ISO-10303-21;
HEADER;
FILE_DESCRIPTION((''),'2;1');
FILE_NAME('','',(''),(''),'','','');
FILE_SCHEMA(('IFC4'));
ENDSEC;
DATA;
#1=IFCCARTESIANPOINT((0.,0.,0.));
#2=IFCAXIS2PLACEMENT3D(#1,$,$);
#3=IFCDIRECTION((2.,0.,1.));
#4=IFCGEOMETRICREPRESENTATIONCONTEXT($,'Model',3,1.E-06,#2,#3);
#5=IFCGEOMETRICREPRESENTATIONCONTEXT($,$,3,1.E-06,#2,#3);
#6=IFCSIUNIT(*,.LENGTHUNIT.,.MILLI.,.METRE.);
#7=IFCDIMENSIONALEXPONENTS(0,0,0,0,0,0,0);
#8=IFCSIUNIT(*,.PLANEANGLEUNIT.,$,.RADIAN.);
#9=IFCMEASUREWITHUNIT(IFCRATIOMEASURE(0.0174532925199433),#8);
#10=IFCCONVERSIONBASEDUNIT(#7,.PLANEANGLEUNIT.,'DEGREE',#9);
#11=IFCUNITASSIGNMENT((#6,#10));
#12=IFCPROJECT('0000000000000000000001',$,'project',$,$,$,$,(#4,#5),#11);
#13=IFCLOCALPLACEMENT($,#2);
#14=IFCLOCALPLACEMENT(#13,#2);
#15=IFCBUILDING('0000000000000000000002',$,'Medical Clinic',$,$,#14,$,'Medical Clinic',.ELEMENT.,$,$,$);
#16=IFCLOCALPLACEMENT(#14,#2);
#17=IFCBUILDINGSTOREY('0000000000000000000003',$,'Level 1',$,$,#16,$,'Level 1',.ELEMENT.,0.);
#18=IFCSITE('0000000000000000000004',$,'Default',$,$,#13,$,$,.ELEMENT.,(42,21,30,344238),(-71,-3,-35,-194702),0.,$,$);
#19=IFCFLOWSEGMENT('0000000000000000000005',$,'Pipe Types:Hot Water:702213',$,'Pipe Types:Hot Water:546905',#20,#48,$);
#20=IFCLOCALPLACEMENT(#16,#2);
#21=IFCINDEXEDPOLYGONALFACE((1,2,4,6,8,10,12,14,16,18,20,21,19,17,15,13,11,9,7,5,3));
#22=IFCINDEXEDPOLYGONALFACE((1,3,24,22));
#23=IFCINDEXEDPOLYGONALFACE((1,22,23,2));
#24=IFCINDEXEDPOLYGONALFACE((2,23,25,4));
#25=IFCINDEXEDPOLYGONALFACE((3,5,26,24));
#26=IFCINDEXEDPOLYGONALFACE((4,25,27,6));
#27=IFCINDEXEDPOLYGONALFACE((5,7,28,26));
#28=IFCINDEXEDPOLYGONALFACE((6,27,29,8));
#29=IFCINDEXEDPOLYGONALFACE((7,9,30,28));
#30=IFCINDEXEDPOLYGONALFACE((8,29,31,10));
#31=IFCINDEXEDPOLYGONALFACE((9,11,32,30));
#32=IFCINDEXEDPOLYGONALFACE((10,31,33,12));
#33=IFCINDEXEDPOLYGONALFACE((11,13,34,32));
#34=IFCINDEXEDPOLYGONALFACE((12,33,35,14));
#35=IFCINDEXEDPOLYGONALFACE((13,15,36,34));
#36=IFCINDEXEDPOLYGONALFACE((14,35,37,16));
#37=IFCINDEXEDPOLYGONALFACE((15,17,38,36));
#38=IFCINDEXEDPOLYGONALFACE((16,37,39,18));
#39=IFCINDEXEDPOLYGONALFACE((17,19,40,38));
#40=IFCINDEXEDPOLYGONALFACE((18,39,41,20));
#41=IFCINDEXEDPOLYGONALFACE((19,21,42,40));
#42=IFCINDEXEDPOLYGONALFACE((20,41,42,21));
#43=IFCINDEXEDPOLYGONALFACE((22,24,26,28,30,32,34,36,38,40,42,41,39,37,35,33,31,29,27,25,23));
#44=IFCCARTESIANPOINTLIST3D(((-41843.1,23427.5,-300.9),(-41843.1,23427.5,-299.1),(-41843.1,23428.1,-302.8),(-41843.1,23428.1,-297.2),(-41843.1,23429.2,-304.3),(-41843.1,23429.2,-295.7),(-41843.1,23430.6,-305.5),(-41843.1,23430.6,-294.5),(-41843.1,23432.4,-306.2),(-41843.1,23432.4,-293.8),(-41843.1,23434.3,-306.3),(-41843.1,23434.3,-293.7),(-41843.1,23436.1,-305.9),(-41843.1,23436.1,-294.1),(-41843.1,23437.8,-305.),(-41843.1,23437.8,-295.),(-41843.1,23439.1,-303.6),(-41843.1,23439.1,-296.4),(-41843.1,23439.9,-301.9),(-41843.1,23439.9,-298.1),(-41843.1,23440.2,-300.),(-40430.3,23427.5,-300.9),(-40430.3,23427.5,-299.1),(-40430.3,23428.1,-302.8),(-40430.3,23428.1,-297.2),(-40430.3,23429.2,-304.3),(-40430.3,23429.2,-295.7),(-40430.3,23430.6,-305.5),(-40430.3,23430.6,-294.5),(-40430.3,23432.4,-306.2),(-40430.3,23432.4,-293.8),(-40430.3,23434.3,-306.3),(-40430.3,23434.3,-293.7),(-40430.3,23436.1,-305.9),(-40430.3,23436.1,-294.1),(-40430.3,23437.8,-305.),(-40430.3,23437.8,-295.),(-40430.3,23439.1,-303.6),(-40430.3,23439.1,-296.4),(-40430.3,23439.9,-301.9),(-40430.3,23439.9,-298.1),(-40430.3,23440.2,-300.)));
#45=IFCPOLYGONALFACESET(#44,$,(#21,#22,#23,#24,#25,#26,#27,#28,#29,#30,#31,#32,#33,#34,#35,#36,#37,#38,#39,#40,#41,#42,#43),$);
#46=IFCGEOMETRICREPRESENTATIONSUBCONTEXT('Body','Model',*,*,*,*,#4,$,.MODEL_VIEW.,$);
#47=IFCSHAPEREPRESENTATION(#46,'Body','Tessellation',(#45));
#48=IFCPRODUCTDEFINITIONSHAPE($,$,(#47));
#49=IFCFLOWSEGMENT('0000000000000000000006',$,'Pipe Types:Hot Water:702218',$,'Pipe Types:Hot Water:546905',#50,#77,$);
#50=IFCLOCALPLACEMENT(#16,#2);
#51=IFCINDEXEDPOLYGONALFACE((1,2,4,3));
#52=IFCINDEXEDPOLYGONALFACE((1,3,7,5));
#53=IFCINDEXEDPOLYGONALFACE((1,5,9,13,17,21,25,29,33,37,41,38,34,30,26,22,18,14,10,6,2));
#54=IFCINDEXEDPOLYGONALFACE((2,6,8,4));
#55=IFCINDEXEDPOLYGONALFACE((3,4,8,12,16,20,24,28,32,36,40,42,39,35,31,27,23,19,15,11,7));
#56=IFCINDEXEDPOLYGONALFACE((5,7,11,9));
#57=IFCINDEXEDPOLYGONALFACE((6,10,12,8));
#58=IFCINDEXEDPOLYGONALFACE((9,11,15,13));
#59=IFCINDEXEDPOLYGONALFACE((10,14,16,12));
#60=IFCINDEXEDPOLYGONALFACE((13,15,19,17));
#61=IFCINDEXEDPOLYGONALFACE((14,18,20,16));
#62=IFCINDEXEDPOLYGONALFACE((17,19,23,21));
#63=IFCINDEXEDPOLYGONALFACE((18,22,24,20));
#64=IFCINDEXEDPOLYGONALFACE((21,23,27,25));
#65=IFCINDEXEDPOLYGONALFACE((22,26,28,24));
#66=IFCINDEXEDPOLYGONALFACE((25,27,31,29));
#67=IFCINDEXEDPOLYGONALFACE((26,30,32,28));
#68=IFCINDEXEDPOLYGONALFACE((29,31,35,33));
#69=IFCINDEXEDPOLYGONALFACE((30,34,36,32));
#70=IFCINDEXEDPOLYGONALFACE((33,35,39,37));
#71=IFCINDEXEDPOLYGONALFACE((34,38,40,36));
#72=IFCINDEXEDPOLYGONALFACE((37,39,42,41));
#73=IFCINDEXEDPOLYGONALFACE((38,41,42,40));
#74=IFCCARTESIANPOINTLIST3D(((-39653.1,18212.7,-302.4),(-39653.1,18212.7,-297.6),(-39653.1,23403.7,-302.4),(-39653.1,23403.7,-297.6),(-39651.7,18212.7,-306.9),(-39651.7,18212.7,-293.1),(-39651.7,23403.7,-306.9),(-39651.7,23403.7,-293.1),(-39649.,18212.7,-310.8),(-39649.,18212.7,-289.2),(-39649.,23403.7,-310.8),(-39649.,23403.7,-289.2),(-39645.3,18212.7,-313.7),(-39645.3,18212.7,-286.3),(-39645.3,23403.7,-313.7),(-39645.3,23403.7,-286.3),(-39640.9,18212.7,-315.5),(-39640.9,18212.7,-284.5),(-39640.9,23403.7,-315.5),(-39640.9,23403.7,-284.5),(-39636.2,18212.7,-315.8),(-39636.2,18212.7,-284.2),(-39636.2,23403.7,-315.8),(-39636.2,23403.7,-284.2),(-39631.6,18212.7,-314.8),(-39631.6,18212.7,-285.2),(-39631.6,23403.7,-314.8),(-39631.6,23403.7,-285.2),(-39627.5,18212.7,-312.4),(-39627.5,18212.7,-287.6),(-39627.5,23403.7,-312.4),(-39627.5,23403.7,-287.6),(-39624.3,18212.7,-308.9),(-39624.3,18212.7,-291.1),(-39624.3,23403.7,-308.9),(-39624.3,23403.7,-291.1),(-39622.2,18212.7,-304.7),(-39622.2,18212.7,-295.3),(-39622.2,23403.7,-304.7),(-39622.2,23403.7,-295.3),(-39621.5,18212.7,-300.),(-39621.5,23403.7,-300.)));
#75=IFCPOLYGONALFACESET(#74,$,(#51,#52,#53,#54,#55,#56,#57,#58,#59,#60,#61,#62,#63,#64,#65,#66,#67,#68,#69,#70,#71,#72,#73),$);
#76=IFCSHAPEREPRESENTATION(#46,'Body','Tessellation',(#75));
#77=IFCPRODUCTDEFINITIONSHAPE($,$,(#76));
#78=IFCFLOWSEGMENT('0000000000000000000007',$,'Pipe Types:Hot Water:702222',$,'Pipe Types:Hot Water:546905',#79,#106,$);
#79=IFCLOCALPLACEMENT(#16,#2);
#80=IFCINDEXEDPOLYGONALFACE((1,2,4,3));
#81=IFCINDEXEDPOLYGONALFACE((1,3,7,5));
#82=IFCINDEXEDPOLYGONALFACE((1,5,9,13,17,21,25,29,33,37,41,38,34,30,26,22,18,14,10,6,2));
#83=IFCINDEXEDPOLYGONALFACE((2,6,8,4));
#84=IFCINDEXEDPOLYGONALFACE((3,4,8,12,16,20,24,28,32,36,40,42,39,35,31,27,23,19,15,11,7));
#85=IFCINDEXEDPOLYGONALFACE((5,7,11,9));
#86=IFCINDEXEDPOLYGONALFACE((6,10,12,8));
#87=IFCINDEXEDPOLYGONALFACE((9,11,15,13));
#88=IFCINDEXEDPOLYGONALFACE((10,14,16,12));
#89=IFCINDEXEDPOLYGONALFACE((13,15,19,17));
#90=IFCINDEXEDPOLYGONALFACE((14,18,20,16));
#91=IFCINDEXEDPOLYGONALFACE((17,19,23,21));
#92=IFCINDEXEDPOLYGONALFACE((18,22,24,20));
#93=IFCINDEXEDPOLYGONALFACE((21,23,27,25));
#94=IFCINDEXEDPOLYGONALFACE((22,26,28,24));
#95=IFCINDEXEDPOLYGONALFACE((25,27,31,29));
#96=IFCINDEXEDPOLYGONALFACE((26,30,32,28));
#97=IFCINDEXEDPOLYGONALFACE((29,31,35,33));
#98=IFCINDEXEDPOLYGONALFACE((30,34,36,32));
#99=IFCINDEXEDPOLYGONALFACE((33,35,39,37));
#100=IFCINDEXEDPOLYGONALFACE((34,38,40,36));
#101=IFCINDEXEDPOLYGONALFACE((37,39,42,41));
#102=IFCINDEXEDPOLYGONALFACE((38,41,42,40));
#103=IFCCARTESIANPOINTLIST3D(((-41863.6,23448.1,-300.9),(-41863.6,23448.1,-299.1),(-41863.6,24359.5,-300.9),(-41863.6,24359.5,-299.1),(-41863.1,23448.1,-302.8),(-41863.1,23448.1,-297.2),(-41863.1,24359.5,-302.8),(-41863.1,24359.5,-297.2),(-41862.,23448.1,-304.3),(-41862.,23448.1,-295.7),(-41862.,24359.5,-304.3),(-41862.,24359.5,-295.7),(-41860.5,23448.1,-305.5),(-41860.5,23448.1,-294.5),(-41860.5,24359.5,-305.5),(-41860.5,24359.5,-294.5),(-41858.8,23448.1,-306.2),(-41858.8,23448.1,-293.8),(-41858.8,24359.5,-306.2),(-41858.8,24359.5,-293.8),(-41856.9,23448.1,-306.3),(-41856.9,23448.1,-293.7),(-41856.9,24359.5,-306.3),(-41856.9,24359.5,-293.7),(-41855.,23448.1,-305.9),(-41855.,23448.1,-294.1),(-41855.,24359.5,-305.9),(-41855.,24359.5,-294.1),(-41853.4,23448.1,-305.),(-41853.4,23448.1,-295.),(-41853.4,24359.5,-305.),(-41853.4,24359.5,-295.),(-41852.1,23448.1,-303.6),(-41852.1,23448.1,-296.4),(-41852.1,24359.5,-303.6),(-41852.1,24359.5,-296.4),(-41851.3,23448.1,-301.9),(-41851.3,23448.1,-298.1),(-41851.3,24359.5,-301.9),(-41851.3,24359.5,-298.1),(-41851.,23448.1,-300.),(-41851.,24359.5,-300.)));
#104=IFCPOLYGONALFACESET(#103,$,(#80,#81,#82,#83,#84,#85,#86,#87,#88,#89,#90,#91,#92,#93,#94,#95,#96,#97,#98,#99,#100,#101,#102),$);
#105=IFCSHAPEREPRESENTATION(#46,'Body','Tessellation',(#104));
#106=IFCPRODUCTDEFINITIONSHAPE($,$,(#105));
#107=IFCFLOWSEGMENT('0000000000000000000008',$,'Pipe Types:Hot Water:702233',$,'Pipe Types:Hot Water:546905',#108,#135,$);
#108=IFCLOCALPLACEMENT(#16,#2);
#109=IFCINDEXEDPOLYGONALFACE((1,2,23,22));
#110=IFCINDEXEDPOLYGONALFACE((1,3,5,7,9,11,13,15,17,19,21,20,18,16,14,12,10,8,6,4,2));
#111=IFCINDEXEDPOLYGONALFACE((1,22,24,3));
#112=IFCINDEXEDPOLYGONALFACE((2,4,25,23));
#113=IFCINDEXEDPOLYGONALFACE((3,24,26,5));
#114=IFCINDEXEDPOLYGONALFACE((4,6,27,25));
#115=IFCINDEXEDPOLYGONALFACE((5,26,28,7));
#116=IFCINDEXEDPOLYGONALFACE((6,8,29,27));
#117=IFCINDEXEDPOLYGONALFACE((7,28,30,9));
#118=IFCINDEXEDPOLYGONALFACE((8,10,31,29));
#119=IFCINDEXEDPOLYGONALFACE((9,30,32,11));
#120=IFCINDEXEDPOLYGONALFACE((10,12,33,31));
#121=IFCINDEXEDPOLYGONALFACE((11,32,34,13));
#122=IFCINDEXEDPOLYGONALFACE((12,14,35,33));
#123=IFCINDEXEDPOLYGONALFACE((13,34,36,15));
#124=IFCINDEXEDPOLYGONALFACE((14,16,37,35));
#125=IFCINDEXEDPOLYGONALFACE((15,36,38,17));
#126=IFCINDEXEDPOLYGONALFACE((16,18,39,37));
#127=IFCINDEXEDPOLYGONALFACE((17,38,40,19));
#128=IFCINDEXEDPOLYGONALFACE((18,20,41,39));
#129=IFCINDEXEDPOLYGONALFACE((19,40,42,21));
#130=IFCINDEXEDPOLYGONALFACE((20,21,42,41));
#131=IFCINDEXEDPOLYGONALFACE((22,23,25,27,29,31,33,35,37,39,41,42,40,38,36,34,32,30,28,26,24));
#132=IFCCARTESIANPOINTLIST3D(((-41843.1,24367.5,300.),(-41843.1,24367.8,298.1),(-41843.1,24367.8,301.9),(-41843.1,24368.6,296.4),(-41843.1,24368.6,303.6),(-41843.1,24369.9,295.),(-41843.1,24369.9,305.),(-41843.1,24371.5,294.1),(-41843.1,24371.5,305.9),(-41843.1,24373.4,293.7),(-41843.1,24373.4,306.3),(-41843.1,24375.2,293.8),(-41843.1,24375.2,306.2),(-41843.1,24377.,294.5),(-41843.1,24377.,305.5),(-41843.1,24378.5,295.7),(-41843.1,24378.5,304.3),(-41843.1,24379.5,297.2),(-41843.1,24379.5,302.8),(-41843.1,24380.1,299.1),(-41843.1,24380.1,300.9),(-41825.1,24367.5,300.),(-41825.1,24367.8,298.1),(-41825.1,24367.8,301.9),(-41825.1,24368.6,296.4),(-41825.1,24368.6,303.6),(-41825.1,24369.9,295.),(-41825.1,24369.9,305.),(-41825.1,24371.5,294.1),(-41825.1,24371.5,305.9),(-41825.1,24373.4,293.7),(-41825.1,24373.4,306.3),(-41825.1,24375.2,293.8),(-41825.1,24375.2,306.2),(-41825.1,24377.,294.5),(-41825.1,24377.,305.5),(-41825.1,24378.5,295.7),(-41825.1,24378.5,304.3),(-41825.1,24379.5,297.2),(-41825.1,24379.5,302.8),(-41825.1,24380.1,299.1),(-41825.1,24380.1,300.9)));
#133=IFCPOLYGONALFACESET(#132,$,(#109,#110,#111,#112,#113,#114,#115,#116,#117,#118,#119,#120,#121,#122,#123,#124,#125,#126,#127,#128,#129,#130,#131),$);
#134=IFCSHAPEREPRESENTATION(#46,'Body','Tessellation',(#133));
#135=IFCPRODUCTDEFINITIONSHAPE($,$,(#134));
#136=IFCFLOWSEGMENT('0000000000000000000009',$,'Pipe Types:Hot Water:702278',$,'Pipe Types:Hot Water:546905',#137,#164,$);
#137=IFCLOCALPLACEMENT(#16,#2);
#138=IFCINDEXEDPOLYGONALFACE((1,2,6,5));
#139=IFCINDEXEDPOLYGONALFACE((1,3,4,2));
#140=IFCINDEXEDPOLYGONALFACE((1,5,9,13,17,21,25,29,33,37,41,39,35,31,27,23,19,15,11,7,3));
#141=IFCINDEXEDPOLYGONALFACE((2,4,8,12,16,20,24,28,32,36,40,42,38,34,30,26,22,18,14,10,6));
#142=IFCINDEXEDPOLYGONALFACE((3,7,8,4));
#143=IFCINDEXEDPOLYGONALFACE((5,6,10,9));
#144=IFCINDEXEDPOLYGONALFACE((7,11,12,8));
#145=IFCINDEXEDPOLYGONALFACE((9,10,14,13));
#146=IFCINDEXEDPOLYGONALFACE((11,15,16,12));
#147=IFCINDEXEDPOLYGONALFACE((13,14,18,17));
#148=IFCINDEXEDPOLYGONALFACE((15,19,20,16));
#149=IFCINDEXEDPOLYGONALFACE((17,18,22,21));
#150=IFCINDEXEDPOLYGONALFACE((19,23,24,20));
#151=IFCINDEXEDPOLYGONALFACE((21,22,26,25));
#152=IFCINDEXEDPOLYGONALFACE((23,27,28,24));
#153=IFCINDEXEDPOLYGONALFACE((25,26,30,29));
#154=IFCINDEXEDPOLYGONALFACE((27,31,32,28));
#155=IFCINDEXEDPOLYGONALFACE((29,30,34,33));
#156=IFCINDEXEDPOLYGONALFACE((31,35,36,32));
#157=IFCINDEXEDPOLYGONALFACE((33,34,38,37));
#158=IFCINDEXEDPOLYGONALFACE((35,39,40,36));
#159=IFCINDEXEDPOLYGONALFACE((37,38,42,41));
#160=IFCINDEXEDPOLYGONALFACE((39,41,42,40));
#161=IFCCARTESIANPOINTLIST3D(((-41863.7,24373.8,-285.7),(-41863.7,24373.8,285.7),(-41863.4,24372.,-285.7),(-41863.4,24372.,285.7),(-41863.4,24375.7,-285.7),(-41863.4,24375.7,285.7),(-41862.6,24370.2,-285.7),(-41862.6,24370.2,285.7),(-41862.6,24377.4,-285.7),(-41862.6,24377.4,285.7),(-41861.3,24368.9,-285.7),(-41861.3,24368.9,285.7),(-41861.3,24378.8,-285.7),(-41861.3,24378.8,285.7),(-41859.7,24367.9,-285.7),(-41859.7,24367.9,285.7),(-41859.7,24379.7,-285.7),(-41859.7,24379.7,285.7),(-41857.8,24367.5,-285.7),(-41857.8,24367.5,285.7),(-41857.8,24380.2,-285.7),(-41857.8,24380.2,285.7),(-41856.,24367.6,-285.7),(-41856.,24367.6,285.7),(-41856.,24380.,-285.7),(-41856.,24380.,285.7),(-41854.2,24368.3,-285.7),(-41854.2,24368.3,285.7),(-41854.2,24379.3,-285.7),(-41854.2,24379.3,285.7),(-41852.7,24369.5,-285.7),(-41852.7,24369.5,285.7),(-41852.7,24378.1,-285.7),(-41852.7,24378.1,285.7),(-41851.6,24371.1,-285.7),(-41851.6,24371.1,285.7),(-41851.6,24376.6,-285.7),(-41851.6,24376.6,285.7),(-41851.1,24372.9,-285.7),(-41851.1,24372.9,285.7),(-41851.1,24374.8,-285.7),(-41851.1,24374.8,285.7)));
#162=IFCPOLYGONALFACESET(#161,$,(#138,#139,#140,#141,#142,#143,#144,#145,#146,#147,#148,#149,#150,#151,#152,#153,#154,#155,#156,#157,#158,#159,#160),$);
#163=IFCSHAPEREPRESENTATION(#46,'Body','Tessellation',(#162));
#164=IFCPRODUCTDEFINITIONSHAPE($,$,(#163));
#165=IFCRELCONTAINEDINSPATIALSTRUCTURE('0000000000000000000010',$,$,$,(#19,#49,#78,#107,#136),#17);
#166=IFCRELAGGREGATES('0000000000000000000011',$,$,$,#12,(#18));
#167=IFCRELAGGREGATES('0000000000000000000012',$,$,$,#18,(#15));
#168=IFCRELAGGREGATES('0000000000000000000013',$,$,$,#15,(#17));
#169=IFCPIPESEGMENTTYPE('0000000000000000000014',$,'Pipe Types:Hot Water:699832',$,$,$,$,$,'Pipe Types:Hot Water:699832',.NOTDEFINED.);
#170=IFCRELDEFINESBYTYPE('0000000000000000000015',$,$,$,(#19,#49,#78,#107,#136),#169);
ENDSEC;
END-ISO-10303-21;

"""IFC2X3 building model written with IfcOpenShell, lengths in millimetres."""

from ifc_helpers import new_model, entity, si_unit, converted_unit, direction, frame, frame_2d, origin, origin_2d_with_axis, place, context, subcontext, project, spatial, circle, extrude, type_object, element, save


model = new_model("IFC2X3")

# Units and contexts
model_context = context("Model", 3, precision=1e-06, world=origin(), true_north=direction((2.0, 0.0, 1.0)))
context_of_model = context(None, 3, precision=1e-06, world=origin(), true_north=direction((2.0, 0.0, 1.0)))
body_context = subcontext(model_context, "Body", "Model", "MODEL_VIEW")
ifc_project = project(units=[si_unit("LENGTHUNIT", "METRE", prefix="MILLI"), converted_unit("PLANEANGLEUNIT", "DEGREE", entity("IfcRatioMeasure", 0.0174532925199433), si_unit("PLANEANGLEUNIT", "RADIAN"), dimensions=[0, 0, 0, 0, 0, 0, 0])], contexts=[model_context, context_of_model])

# Site, building, storey
site_placement = place(None, origin())
site = spatial("IfcSite", under=ifc_project, at=site_placement, Name="Default", CompositionType="ELEMENT", RefLatitude=(42, 21, 30, 344238), RefLongitude=(-71, -3, -35, -194702), RefElevation=0.0)
building_placement = place(site_placement, origin())
building = spatial("IfcBuilding", under=site, at=building_placement, Name="Medical Clinic", LongName="Medical Clinic", CompositionType="ELEMENT")
storey_placement = place(building_placement, origin())
storey = spatial("IfcBuildingStorey", under=building, at=storey_placement, Name="Level 1", LongName="Level 1", CompositionType="ELEMENT", Elevation=0.0)

# Flow segments
pipe_segment_type_1 = type_object("IfcPipeSegmentType", Name="Pipe Types:Hot Water:699832", ElementType="Pipe Types:Hot Water:699832", PredefinedType="NOTDEFINED")
flow_segment_1_placement = place(storey_placement, origin())
element("IfcFlowSegment", 1, at=flow_segment_1_placement, inside=storey, type_object=pipe_segment_type_1, Name="Pipe Types:Hot Water:702213", ObjectType="Pipe Types:Hot Water:546905", context=body_context, shape_type="SweptSolid", body=[
    extrude(circle(Radius=6.3, at=frame_2d((0.0, 0.0), x_axis=(1.0, 0.0))), frame((-41843.1, 23433.8, -300.0), z_axis=(1.0, 0.0, 0.0), x_axis=(0.0, 1.0, 0.0)), (0.0, 0.0, 1.0), 1412.7),
])
flow_segment_2_placement = place(storey_placement, origin())
element("IfcFlowSegment", 2, at=flow_segment_2_placement, inside=storey, type_object=pipe_segment_type_1, Name="Pipe Types:Hot Water:702218", ObjectType="Pipe Types:Hot Water:546905", context=body_context, shape_type="SweptSolid", body=[
    extrude(circle(Radius=15.9, at=origin_2d_with_axis()), frame((-39637.4, 18212.7, -300.0), z_axis=(0.0, 1.0, 0.0), x_axis=(1.0, 0.0, 0.0)), (0.0, 0.0, 1.0), 5191.0),
])
flow_segment_3_placement = place(storey_placement, origin())
element("IfcFlowSegment", 3, at=flow_segment_3_placement, inside=storey, type_object=pipe_segment_type_1, Name="Pipe Types:Hot Water:702222", ObjectType="Pipe Types:Hot Water:546905", context=body_context, shape_type="SweptSolid", body=[
    extrude(circle(Radius=6.3, at=origin_2d_with_axis()), frame((-41857.4, 23448.1, -300.0), z_axis=(0.0, 1.0, 0.0), x_axis=(1.0, 0.0, 0.0)), (0.0, 0.0, 1.0), 911.4),
])
flow_segment_4_placement = place(storey_placement, origin())
element("IfcFlowSegment", 4, at=flow_segment_4_placement, inside=storey, type_object=pipe_segment_type_1, Name="Pipe Types:Hot Water:702233", ObjectType="Pipe Types:Hot Water:546905", context=body_context, shape_type="SweptSolid", body=[
    extrude(circle(Radius=6.3, at=origin_2d_with_axis()), frame((-41843.1, 24373.8, 300.0), z_axis=(1.0, 0.0, 0.0), x_axis=(0.0, -1.0, 0.0)), (0.0, 0.0, 1.0), 18.0),
])
flow_segment_5_placement = place(storey_placement, origin())
element("IfcFlowSegment", 5, at=flow_segment_5_placement, inside=storey, type_object=pipe_segment_type_1, Name="Pipe Types:Hot Water:702278", ObjectType="Pipe Types:Hot Water:546905", context=body_context, shape_type="SweptSolid", body=[
    extrude(circle(Radius=6.3, at=origin_2d_with_axis()), frame((-41857.4, 24373.8, -285.7), z_axis=(0.0, 0.0, 1.0), x_axis=(-1.0, 0.0, 0.0)), (0.0, 0.0, 1.0), 571.4),
])

save(model, "model.ifc")
